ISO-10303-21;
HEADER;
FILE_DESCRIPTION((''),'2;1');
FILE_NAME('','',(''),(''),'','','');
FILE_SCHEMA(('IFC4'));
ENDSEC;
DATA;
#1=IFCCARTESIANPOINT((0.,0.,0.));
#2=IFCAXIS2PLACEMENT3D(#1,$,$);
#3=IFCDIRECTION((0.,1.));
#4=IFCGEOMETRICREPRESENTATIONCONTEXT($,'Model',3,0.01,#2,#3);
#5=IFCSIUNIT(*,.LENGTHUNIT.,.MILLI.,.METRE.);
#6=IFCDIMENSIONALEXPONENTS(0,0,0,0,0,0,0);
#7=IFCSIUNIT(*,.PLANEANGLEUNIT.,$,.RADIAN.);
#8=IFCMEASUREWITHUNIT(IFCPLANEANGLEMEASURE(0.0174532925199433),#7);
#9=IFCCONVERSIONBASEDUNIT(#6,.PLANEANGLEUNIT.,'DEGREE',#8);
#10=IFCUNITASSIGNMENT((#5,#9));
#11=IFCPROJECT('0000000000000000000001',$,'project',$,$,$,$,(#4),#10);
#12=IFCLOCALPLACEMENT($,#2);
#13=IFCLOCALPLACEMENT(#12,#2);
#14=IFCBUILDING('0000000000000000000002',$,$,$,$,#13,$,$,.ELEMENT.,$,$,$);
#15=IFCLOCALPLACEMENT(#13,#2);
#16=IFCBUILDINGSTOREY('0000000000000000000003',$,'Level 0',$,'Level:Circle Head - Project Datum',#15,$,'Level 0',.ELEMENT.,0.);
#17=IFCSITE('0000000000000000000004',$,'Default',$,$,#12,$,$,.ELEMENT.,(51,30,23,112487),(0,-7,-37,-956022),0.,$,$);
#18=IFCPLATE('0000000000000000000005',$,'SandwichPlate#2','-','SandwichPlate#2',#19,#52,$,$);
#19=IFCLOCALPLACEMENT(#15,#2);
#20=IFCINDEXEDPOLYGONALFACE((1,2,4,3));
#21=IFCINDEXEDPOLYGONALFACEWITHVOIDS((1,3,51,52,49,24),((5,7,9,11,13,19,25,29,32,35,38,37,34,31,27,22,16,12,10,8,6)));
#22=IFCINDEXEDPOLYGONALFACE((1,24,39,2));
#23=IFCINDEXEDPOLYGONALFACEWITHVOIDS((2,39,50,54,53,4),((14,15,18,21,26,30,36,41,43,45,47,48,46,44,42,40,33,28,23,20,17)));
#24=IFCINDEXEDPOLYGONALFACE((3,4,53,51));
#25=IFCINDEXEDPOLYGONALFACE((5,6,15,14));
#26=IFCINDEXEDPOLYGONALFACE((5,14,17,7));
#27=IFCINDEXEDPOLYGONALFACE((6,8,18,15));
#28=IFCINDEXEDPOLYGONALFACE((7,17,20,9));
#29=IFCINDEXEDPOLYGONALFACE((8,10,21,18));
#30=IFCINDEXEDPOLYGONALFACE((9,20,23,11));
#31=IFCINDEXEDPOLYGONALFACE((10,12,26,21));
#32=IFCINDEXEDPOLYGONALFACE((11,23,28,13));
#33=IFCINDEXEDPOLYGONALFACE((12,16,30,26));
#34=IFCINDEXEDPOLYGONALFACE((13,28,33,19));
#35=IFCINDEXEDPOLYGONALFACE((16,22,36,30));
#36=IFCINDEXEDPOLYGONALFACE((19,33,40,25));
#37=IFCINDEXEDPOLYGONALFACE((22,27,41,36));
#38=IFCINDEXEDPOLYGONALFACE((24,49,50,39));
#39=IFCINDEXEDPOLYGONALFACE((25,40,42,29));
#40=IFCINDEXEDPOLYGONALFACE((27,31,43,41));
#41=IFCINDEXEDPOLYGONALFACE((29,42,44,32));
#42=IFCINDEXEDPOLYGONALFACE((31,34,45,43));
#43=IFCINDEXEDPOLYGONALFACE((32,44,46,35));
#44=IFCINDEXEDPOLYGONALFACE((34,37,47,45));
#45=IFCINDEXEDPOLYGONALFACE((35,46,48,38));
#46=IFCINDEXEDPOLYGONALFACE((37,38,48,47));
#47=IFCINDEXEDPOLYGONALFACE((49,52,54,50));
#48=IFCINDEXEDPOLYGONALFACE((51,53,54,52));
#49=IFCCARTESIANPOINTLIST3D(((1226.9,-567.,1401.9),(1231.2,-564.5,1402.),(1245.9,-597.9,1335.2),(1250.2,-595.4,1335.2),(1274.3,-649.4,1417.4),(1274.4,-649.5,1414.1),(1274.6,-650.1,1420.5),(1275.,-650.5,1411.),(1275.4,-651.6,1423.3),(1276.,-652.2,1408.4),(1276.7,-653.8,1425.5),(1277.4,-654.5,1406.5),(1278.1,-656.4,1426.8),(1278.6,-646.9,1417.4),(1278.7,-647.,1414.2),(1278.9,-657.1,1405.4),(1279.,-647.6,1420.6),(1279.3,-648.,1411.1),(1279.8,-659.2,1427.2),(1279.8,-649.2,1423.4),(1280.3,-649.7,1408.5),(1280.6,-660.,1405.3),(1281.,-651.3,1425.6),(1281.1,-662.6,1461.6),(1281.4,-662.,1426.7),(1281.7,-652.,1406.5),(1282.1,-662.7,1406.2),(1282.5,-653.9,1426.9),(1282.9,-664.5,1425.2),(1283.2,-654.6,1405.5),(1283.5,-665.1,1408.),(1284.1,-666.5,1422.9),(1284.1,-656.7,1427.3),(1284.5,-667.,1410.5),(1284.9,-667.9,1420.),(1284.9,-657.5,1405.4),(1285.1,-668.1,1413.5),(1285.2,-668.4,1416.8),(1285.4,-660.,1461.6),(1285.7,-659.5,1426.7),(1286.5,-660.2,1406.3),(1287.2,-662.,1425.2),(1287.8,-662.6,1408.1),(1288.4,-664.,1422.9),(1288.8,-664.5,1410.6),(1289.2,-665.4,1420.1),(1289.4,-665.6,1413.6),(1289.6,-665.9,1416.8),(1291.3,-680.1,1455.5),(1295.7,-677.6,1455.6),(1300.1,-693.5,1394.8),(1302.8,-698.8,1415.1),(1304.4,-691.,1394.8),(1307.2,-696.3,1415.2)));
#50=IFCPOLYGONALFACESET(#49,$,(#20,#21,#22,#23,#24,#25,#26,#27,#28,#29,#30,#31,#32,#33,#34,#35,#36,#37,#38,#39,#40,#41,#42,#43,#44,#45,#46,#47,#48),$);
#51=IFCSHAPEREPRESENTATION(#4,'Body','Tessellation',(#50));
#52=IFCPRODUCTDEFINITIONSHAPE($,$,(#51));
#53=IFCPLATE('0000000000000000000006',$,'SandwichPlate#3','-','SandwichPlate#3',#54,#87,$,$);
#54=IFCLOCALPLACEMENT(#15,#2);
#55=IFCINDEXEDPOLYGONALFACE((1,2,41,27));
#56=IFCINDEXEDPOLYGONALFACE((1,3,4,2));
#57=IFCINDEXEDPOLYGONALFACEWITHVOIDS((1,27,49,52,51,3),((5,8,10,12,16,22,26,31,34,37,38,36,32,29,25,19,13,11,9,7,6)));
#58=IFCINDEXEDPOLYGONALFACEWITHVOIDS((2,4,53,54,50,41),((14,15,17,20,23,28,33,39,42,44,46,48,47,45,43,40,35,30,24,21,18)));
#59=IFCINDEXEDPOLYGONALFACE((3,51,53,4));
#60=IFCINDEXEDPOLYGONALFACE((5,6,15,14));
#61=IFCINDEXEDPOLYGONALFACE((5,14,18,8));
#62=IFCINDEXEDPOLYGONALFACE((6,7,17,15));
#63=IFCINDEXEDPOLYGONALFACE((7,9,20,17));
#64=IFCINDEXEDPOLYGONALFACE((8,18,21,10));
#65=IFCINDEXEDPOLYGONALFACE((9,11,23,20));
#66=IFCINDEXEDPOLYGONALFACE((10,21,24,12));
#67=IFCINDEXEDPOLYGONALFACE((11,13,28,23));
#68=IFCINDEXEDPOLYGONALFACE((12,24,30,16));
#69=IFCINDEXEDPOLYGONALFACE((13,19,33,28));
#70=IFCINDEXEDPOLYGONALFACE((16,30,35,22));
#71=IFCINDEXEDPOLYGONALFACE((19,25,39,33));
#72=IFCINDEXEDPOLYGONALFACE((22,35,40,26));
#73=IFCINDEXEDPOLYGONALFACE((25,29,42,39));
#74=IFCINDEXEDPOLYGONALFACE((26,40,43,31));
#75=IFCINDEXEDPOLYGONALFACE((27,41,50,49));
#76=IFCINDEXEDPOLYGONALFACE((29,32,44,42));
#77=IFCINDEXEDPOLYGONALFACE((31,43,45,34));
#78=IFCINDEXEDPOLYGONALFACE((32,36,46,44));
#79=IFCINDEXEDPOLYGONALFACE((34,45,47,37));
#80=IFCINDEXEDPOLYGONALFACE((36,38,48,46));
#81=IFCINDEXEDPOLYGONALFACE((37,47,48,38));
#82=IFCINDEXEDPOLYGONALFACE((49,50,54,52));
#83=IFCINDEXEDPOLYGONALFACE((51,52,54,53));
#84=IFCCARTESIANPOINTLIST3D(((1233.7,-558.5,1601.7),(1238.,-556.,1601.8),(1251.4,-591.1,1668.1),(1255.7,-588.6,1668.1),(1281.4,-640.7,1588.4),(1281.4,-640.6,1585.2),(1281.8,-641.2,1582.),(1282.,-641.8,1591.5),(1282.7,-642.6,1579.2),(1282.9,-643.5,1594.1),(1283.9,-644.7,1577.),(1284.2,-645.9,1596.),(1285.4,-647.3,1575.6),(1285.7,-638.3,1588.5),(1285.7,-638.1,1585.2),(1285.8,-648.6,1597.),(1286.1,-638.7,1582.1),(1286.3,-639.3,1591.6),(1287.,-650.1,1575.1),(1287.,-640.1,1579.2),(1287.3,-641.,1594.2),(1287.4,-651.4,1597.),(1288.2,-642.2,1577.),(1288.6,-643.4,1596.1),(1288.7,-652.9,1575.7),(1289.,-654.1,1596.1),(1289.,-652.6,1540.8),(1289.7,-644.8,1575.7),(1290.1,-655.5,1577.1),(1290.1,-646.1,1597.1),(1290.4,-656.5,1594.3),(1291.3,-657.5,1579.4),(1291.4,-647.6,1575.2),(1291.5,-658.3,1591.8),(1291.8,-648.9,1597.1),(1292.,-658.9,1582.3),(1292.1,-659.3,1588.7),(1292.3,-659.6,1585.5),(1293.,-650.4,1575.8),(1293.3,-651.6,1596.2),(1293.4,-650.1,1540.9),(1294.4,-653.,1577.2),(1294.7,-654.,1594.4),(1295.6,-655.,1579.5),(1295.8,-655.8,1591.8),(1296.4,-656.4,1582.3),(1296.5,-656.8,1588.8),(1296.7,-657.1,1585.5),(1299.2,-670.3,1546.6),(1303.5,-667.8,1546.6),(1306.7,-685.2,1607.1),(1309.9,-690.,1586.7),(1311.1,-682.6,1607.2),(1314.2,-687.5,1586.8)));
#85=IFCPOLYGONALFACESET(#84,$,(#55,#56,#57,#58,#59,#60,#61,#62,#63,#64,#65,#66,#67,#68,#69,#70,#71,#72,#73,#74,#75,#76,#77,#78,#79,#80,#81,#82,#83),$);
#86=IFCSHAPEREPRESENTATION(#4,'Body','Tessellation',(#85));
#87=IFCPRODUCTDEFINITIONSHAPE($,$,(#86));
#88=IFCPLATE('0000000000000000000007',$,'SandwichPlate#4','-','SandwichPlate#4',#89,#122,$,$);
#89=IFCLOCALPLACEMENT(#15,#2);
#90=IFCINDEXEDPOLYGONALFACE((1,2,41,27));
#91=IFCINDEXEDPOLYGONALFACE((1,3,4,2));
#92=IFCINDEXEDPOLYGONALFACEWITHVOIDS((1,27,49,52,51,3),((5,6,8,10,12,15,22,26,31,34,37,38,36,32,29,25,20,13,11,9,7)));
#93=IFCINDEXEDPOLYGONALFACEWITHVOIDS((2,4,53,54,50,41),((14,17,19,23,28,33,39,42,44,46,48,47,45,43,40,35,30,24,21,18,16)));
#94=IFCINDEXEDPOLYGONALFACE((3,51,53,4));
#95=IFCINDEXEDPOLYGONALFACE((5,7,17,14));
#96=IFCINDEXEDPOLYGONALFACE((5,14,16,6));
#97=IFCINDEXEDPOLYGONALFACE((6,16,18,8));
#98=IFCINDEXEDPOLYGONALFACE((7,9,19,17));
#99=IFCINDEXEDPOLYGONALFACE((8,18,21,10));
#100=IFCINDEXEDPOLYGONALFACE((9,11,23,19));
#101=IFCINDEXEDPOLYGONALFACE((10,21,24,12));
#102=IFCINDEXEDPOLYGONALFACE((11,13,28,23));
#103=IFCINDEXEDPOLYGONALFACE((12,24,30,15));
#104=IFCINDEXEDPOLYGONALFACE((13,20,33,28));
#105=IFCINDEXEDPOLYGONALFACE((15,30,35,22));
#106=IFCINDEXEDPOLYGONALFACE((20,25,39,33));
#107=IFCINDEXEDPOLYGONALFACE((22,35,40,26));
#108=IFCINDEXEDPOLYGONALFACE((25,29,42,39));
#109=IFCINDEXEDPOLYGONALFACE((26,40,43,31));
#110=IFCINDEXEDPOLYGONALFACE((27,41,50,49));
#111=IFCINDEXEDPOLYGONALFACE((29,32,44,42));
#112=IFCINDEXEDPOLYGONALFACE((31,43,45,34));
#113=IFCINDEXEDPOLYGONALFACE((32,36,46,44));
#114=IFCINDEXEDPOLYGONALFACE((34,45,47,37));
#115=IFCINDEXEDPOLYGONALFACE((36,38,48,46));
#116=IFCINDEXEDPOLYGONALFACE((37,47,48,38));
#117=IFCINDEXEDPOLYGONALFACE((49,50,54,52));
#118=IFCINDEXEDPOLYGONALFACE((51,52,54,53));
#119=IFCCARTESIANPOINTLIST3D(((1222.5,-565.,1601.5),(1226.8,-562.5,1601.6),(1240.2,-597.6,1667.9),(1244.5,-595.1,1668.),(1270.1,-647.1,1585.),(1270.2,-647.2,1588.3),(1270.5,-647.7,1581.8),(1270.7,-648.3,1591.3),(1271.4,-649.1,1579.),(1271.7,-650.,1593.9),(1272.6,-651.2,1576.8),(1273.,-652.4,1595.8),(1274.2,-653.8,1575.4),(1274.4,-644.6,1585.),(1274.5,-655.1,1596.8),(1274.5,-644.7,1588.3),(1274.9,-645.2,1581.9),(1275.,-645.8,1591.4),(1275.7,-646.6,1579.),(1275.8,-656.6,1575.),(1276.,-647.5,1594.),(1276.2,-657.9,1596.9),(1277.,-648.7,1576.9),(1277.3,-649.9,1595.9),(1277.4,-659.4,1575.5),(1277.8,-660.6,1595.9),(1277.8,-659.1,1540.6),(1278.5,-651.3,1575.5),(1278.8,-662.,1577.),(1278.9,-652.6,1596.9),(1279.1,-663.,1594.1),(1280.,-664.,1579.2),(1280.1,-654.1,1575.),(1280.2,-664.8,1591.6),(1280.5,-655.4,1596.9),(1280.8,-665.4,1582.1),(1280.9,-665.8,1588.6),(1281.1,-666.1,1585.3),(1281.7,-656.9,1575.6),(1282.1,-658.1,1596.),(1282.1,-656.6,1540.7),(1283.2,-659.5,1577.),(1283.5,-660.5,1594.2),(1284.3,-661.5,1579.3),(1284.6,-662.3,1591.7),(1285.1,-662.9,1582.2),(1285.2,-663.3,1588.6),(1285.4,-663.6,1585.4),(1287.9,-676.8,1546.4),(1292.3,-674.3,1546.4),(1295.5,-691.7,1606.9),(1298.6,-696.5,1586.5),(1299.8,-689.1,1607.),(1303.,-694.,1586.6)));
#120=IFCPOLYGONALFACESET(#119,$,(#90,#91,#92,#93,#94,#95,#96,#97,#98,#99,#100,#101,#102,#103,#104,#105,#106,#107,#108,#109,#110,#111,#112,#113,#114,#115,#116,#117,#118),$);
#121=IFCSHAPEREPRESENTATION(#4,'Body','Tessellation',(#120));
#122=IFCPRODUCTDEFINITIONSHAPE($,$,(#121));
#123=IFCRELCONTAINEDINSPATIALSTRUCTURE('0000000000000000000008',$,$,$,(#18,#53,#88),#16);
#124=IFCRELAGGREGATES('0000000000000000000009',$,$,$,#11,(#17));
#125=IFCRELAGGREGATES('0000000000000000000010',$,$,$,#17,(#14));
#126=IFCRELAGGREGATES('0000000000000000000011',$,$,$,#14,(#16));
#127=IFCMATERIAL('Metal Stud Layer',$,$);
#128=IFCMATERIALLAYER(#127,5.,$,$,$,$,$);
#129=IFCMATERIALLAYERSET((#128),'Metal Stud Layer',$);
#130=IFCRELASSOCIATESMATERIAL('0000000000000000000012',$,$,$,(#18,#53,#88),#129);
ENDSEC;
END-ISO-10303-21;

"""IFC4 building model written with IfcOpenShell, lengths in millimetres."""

from ifc_helpers import new_model, entity, si_unit, converted_unit, direction, frame, origin, origin_with_axes, origin_2d_with_axis, place, context, project, spatial, polyline, circle, outline, extrude, material, layer, layer_set, element, save


model = new_model("IFC4")

# Units and contexts
model_context = context("Model", 3, precision=0.01, world=origin(), true_north=direction((0.0, 1.0)))
ifc_project = project(units=[si_unit("LENGTHUNIT", "METRE", prefix="MILLI"), converted_unit("PLANEANGLEUNIT", "DEGREE", entity("IfcPlaneAngleMeasure", 0.0174532925199433), si_unit("PLANEANGLEUNIT", "RADIAN"), dimensions=[0, 0, 0, 0, 0, 0, 0])], contexts=[model_context])

# Site, building, storey
site_placement = place(None, origin())
site = spatial("IfcSite", under=ifc_project, at=site_placement, Name="Default", CompositionType="ELEMENT", RefLatitude=(51, 30, 23, 112487), RefLongitude=(0, -7, -37, -956022), RefElevation=0.0)
building_placement = place(site_placement, origin())
building = spatial("IfcBuilding", under=site, at=building_placement, CompositionType="ELEMENT")
storey_placement = place(building_placement, origin())
storey = spatial("IfcBuildingStorey", under=building, at=storey_placement, Name="Level 0", ObjectType="Level:Circle Head - Project Datum", LongName="Level 0", CompositionType="ELEMENT", Elevation=0.0)

# Shared definitions
ifc_material_1 = material(Name="Metal Stud Layer")

# Shared definitions
ifc_layer_1 = layer(ifc_material_1, 5.0)
ifc_layer_set_1 = layer_set([ifc_layer_1], Name="Metal Stud Layer")

# Plates, openings
plate_1_placement = place(storey_placement, frame((1310.9, -702.4, 1402.0), z_axis=(-0.865935, -0.499948, -0.014432), x_axis=(-0.249453, 0.406695, 0.878847)))
plate_1 = element("IfcPlate", 1, at=plate_1_placement, inside=storey, material=ifc_layer_set_1, Name="SandwichPlate#2", Description="-", ObjectType="SandwichPlate#2", context=model_context, shape_type="SweptSolid", body=[
    extrude(outline(polyline([(0.0, 0.0), (76.0, 0.0), (76.0, 140.0), (0.0, 140.0), (0.0, 0.0)])), origin_with_axes(), (0.0, 0.0, 1.0), 5.0),
])
opening_1_placement = place(plate_1_placement, frame((0.0, 0.0, 0.0), z_axis=(0.0, 0.0, 1.0), x_axis=(1.0, 0.0, 0.0)))
element("IfcOpeningElement", 2, at=opening_1_placement, cuts=plate_1, ObjectType="Opening", context=model_context, shape_type="SweptSolid", body=[
    extrude(outline(polyline([(0.0, 0.0), (15.0, 0.0), (0.0, 15.0), (0.0, 0.0)])), origin(), (0.0, 0.0, 1.0), 5.0),
])
opening_2_placement = place(plate_1_placement, frame((0.0, 0.0, 0.0), z_axis=(0.0, 0.0, 1.0), x_axis=(1.0, 0.0, 0.0)))
element("IfcOpeningElement", 3, at=opening_2_placement, cuts=plate_1, ObjectType="Opening", context=model_context, shape_type="SweptSolid", body=[
    extrude(outline(polyline([(76.0, 0.0), (76.0, 15.0), (61.0, 0.0), (76.0, 0.0)])), origin(), (0.0, 0.0, 1.0), 5.0),
])
opening_3_placement = place(plate_1_placement, frame((38.0, 40.0, -0.5), z_axis=(0.0, 0.0, 1.0), x_axis=(0.0, 1.0, 0.0)))
element("IfcOpeningElement", 4, at=opening_3_placement, cuts=plate_1, ObjectType="Opening", context=model_context, shape_type="SweptSolid", body=[
    extrude(circle(Radius=11.0, at=origin_2d_with_axis()), origin(), (0.0, 0.0, 1.0), 6.0),
])
plate_2_placement = place(storey_placement, frame((1300.0, -661.4, 1533.5), z_axis=(-0.865935, -0.499948, -0.014432), x_axis=(0.232925, -0.428638, 0.872935)))
plate_2 = element("IfcPlate", 5, at=plate_2_placement, inside=storey, material=ifc_layer_set_1, Name="SandwichPlate#3", Description="-", ObjectType="SandwichPlate#3", context=model_context, shape_type="SweptSolid", body=[
    extrude(outline(polyline([(0.0, 0.0), (76.0, 0.0), (76.0, 140.0), (0.0, 140.0), (0.0, 0.0)])), origin_with_axes(), (0.0, 0.0, 1.0), 5.0),
])
opening_4_placement = place(plate_2_placement, frame((0.0, 0.0, 0.0), z_axis=(0.0, 0.0, 1.0), x_axis=(1.0, 0.0, 0.0)))
element("IfcOpeningElement", 6, at=opening_4_placement, cuts=plate_2, ObjectType="Opening", context=model_context, shape_type="SweptSolid", body=[
    extrude(outline(polyline([(0.0, 0.0), (15.0, 0.0), (0.0, 15.0), (0.0, 0.0)])), origin(), (0.0, 0.0, 1.0), 5.0),
])
opening_5_placement = place(plate_2_placement, frame((0.0, 0.0, 0.0), z_axis=(0.0, 0.0, 1.0), x_axis=(1.0, 0.0, 0.0)))
element("IfcOpeningElement", 7, at=opening_5_placement, cuts=plate_2, ObjectType="Opening", context=model_context, shape_type="SweptSolid", body=[
    extrude(outline(polyline([(76.0, 0.0), (76.0, 15.0), (61.0, 0.0), (76.0, 0.0)])), origin(), (0.0, 0.0, 1.0), 5.0),
])
opening_6_placement = place(plate_2_placement, frame((38.0, 40.0, -0.5), z_axis=(0.0, 0.0, 1.0), x_axis=(0.0, 1.0, 0.0)))
element("IfcOpeningElement", 8, at=opening_6_placement, cuts=plate_2, ObjectType="Opening", context=model_context, shape_type="SweptSolid", body=[
    extrude(circle(Radius=11.0, at=origin_2d_with_axis()), origin(), (0.0, 0.0, 1.0), 6.0),
])
plate_3_placement = place(storey_placement, frame((1288.7, -667.9, 1533.4), z_axis=(-0.865935, -0.499948, -0.014432), x_axis=(0.232925, -0.428638, 0.872935)))
plate_3 = element("IfcPlate", 9, at=plate_3_placement, inside=storey, material=ifc_layer_set_1, Name="SandwichPlate#4", Description="-", ObjectType="SandwichPlate#4", context=model_context, shape_type="SweptSolid", body=[
    extrude(outline(polyline([(0.0, 0.0), (76.0, 0.0), (76.0, 140.0), (0.0, 140.0), (0.0, 0.0)])), origin_with_axes(), (0.0, 0.0, 1.0), 5.0),
])
opening_7_placement = place(plate_3_placement, frame((0.0, 0.0, 0.0), z_axis=(0.0, 0.0, 1.0), x_axis=(1.0, 0.0, 0.0)))
element("IfcOpeningElement", 10, at=opening_7_placement, cuts=plate_3, ObjectType="Opening", context=model_context, shape_type="SweptSolid", body=[
    extrude(outline(polyline([(0.0, 0.0), (15.0, 0.0), (0.0, 15.0), (0.0, 0.0)])), origin(), (0.0, 0.0, 1.0), 5.0),
])
opening_8_placement = place(plate_3_placement, frame((0.0, 0.0, 0.0), z_axis=(0.0, 0.0, 1.0), x_axis=(1.0, 0.0, 0.0)))
element("IfcOpeningElement", 11, at=opening_8_placement, cuts=plate_3, ObjectType="Opening", context=model_context, shape_type="SweptSolid", body=[
    extrude(outline(polyline([(76.0, 0.0), (76.0, 15.0), (61.0, 0.0), (76.0, 0.0)])), origin(), (0.0, 0.0, 1.0), 5.0),
])
opening_9_placement = place(plate_3_placement, frame((38.0, 40.0, -0.5), z_axis=(0.0, 0.0, 1.0), x_axis=(0.0, 1.0, 0.0)))
element("IfcOpeningElement", 12, at=opening_9_placement, cuts=plate_3, ObjectType="Opening", context=model_context, shape_type="SweptSolid", body=[
    extrude(circle(Radius=11.0, at=origin_2d_with_axis()), origin(), (0.0, 0.0, 1.0), 6.0),
])

save(model, "model.ifc")
